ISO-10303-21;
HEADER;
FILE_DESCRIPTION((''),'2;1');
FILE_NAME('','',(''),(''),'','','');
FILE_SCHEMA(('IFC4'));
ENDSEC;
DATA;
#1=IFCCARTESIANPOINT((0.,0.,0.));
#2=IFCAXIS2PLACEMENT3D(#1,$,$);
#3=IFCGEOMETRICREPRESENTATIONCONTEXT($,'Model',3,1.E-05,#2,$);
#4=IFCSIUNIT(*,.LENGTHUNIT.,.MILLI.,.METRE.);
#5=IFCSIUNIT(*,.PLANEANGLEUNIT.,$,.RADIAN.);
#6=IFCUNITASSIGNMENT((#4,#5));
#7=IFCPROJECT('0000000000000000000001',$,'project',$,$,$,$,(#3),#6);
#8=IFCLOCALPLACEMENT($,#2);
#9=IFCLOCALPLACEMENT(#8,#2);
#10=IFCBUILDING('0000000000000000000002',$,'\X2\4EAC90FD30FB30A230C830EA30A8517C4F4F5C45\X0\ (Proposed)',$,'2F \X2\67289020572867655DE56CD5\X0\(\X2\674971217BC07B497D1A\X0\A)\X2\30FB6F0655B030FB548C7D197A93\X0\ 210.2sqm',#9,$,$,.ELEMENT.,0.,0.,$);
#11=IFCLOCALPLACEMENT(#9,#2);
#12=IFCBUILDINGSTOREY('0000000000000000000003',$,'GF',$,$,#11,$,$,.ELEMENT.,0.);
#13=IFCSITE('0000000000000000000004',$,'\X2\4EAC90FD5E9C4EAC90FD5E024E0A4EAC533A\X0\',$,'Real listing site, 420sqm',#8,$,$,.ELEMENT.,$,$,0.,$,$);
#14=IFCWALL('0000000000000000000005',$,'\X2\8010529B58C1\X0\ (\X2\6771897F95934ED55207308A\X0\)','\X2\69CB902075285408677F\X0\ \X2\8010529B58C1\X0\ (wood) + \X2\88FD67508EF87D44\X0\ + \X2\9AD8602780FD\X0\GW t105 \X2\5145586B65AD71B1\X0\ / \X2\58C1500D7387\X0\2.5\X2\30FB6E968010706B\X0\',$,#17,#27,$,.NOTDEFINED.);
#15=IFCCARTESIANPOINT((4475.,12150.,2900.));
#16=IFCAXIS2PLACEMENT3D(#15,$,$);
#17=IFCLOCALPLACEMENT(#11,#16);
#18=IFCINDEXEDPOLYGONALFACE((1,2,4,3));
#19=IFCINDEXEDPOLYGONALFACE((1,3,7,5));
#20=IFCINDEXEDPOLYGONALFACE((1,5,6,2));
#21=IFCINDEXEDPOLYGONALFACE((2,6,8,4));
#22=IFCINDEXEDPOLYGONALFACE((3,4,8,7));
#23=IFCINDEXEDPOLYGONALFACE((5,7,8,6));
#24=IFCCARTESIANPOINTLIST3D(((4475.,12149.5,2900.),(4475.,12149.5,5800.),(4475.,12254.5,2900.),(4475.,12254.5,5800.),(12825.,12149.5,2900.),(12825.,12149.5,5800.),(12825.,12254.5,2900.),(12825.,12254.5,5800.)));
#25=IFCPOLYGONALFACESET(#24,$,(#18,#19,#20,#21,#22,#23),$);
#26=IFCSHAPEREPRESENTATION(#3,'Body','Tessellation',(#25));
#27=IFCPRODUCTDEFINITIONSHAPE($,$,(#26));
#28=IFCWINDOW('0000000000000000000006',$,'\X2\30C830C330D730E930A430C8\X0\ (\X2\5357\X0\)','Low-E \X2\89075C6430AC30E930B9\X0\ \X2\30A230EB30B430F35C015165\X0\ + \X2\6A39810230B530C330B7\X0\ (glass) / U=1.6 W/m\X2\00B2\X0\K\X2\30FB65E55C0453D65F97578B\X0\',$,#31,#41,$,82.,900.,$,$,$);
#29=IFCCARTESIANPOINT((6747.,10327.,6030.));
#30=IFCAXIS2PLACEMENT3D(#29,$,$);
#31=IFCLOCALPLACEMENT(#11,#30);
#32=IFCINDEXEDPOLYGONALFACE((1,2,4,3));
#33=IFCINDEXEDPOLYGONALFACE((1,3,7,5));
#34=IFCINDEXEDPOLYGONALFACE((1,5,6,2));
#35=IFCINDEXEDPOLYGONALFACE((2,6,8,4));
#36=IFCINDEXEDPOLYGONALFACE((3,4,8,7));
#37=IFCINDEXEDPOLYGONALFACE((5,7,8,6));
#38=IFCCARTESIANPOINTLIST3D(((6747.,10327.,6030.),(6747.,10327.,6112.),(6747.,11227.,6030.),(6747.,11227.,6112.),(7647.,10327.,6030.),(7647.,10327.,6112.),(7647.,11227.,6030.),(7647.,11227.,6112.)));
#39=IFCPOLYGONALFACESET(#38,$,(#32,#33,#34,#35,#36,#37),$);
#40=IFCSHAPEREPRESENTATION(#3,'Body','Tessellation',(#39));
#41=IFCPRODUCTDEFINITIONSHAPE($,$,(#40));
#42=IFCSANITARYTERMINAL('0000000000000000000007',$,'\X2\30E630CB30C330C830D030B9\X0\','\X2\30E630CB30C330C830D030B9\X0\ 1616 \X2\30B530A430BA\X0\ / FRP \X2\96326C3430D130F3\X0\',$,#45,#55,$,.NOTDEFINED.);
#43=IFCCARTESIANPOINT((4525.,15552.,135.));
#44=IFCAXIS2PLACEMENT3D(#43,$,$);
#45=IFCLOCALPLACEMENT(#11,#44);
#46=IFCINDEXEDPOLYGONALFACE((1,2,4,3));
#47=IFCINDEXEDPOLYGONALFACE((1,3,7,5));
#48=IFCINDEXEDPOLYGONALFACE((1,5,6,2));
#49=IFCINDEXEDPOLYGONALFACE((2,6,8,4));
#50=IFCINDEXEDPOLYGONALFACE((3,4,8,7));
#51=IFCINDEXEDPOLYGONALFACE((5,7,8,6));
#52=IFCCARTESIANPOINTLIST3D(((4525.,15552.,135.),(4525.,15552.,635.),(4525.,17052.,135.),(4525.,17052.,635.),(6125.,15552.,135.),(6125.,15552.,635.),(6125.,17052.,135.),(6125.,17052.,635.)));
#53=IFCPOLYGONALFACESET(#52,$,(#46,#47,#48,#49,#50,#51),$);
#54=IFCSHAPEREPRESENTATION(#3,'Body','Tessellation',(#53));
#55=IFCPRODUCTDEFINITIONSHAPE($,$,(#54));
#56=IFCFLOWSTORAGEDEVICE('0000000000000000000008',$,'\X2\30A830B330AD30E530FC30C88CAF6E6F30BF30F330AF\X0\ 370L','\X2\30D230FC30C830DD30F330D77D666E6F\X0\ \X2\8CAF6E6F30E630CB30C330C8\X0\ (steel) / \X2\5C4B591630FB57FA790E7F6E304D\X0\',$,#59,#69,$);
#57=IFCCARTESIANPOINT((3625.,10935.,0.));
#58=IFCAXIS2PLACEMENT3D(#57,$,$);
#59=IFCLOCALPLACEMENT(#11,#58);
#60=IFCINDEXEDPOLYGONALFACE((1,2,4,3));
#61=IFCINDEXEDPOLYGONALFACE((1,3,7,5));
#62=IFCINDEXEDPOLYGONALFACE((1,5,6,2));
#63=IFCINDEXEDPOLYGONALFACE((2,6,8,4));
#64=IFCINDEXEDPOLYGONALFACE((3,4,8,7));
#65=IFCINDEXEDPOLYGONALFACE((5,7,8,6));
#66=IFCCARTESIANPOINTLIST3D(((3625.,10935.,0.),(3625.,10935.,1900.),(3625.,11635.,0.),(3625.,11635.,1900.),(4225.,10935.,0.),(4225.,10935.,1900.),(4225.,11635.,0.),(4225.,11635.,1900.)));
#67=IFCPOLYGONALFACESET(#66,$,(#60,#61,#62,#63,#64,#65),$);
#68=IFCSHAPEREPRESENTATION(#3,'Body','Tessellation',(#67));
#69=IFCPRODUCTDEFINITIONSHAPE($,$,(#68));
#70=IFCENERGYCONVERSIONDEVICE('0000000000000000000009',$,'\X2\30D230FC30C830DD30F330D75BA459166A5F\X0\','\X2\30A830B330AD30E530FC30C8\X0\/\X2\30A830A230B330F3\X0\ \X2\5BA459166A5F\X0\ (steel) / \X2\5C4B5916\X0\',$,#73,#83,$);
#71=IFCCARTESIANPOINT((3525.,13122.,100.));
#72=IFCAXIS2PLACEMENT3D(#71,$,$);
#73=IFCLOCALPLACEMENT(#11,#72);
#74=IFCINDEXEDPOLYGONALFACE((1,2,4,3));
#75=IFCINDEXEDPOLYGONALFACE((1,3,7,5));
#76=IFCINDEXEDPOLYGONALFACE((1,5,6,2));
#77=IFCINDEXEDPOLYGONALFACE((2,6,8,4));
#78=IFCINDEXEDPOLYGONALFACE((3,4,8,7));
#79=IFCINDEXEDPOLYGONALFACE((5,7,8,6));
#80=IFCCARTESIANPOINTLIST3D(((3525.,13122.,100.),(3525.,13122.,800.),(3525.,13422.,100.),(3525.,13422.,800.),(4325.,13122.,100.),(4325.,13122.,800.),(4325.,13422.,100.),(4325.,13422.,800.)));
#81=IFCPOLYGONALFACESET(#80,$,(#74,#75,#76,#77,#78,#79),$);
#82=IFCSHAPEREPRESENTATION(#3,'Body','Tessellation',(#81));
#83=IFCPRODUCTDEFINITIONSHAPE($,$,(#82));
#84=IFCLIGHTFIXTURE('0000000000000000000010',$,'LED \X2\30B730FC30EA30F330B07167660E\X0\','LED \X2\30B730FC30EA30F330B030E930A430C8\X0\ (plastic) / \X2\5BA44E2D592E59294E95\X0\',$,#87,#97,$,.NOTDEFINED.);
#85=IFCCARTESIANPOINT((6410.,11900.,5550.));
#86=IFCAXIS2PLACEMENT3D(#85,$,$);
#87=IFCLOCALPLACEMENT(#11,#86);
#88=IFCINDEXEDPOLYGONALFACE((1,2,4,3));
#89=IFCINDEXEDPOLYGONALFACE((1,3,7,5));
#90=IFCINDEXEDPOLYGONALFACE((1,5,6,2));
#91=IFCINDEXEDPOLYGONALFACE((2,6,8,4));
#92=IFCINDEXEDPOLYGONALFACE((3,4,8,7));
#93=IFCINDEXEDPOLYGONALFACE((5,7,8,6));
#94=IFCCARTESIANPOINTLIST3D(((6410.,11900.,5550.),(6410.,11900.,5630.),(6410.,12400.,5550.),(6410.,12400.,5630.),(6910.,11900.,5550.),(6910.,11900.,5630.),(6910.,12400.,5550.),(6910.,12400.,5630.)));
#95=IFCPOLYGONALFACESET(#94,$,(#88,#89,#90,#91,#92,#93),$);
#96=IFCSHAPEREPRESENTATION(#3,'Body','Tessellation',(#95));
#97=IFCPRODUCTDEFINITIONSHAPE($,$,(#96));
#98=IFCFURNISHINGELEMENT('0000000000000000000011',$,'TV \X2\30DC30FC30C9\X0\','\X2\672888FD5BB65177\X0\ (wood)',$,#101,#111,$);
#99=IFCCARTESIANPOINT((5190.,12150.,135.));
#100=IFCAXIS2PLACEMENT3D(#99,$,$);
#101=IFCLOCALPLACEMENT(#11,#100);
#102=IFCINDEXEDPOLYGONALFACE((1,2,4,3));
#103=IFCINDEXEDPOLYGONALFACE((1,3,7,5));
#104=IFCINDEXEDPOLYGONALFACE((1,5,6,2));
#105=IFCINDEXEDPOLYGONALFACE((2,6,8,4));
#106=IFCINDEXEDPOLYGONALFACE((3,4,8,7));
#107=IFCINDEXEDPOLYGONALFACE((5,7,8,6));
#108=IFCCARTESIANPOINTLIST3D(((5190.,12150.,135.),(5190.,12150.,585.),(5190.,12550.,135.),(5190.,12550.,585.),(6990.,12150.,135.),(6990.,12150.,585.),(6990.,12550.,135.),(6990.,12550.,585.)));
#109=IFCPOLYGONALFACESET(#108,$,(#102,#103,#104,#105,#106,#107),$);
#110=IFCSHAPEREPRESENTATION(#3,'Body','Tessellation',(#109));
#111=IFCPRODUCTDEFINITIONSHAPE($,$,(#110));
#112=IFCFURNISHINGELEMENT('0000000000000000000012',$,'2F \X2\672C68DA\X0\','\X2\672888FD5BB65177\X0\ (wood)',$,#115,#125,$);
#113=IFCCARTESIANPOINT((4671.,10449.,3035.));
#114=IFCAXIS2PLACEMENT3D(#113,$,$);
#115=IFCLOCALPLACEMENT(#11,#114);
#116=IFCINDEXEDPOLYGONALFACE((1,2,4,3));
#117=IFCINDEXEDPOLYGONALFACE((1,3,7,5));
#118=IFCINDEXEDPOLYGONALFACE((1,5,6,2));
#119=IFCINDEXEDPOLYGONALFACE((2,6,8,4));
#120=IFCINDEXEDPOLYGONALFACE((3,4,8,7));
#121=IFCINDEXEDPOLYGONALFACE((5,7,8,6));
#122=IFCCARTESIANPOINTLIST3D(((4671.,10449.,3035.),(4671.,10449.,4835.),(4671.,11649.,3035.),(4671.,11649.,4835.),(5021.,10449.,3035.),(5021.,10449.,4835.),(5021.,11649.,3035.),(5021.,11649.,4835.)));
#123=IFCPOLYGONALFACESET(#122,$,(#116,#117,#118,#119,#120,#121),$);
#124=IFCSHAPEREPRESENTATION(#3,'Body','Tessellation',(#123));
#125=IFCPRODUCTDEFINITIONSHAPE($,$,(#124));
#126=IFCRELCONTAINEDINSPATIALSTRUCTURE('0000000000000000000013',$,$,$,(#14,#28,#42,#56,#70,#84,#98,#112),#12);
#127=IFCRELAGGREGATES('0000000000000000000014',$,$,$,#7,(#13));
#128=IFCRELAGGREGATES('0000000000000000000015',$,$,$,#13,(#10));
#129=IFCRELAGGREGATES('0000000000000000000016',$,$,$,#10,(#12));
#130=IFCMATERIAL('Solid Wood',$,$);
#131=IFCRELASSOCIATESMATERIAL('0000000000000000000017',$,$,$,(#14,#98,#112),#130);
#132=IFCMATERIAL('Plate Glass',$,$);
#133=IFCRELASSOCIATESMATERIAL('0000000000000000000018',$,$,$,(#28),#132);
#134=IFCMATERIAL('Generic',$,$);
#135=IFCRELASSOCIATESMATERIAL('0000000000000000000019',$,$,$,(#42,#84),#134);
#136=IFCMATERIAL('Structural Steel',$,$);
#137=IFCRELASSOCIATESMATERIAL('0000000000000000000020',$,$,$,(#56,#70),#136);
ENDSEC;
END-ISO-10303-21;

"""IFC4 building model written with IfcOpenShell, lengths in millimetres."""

from ifc_helpers import new_model, si_unit, frame, frame_2d, origin, place, context, project, spatial, rectangle, extrude, material, element, save


model = new_model("IFC4")

# Units and contexts
model_context = context("Model", 3, precision=1e-05, world=origin())
ifc_project = project(units=[si_unit("LENGTHUNIT", "METRE", prefix="MILLI"), si_unit("PLANEANGLEUNIT", "RADIAN")], contexts=[model_context])

# Site, building, storey
site_placement = place(None, origin())
site = spatial("IfcSite", under=ifc_project, at=site_placement, Name="京都府京都市上京区", ObjectType="Real listing site, 420sqm", CompositionType="ELEMENT", RefElevation=0.0)
building_placement = place(site_placement, origin())
building = spatial("IfcBuilding", under=site, at=building_placement, Name="京都・アトリエ兼住居 (Proposed)", ObjectType="2F 木造在来工法(杉無節等級A)・漆喰・和紙窓 210.2sqm", CompositionType="ELEMENT", ElevationOfRefHeight=0.0, ElevationOfTerrain=0.0)
storey_placement = place(building_placement, origin())
storey = spatial("IfcBuildingStorey", under=building, at=storey_placement, Name="GF", CompositionType="ELEMENT", Elevation=0.0)

# Shared definitions
ifc_material_1 = material(Name="Solid Wood")

# Wall
wall_1_placement = place(storey_placement, frame((4475.0, 12150.0, 2900.0)))
element("IfcWall", 1, at=wall_1_placement, inside=storey, material=ifc_material_1, Name="耐力壁 (東西間仕切り)", Description="構造用合板 耐力壁 (wood) + 製材軸組 + 高性能GW t105 充填断熱 / 壁倍率2.5・準耐火", PredefinedType="NOTDEFINED", context=model_context, shape_type="SweptSolid", body=[
    extrude(rectangle(XDim=8350.0, YDim=105.0, at=frame_2d((4175.0, 52.0))), frame((4475.0, 12150.0, 2900.0)), (0.0, 0.0, 1.0), 2900.0),
])

# Window
ifc_material_2 = material(Name="Plate Glass")
window_placement = place(storey_placement, frame((6747.0, 10327.0, 6030.0)))
element("IfcWindow", 2, at=window_placement, inside=storey, material=ifc_material_2, Name="トップライト (南)", Description="Low-E 複層ガラス アルゴン封入 + 樹脂サッシ (glass) / U=1.6 W/m²K・日射取得型", OverallHeight=82.0, OverallWidth=900.0, context=model_context, shape_type="SweptSolid", body=[
    extrude(rectangle(XDim=900.0, YDim=900.0, at=frame_2d((450.0, 450.0))), frame((6747.0, 10327.0, 6030.0)), (0.0, 0.0, 1.0), 82.0),
])

# Sanitary terminal
ifc_material_3 = material(Name="Generic")
sanitary_terminal_placement = place(storey_placement, frame((4525.0, 15552.0, 135.0)))
element("IfcSanitaryTerminal", 3, at=sanitary_terminal_placement, inside=storey, material=ifc_material_3, Name="ユニットバス", Description="ユニットバス 1616 サイズ / FRP 防水パン", PredefinedType="NOTDEFINED", context=model_context, shape_type="SweptSolid", body=[
    extrude(rectangle(XDim=1600.0, YDim=1500.0, at=frame_2d((800.0, 750.0))), frame((4525.0, 15552.0, 135.0)), (0.0, 0.0, 1.0), 500.0),
])

# Flow storage device
ifc_material_4 = material(Name="Structural Steel")
flow_storage_device_placement = place(storey_placement, frame((3625.0, 10935.0, 0.0)))
element("IfcFlowStorageDevice", 4, at=flow_storage_device_placement, inside=storey, material=ifc_material_4, Name="エコキュート貯湯タンク 370L", Description="ヒートポンプ給湯 貯湯ユニット (steel) / 屋外・基礎置き", context=model_context, shape_type="SweptSolid", body=[
    extrude(rectangle(XDim=600.0, YDim=700.0, at=frame_2d((300.0, 350.0))), frame((3625.0, 10935.0, 0.0)), (0.0, 0.0, 1.0), 1900.0),
])

# Energy conversion device
energy_conversion_device_placement = place(storey_placement, frame((3525.0, 13122.0, 100.0)))
element("IfcEnergyConversionDevice", 5, at=energy_conversion_device_placement, inside=storey, material=ifc_material_4, Name="ヒートポンプ室外機", Description="エコキュート/エアコン 室外機 (steel) / 屋外", context=model_context, shape_type="SweptSolid", body=[
    extrude(rectangle(XDim=800.0, YDim=300.0, at=frame_2d((400.0, 150.0))), frame((3525.0, 13122.0, 100.0)), (0.0, 0.0, 1.0), 700.0),
])

# Light fixture
light_fixture_placement = place(storey_placement, frame((6410.0, 11900.0, 5550.0)))
element("IfcLightFixture", 6, at=light_fixture_placement, inside=storey, material=ifc_material_3, Name="LED シーリング照明", Description="LED シーリングライト (plastic) / 室中央天井", PredefinedType="NOTDEFINED", context=model_context, shape_type="SweptSolid", body=[
    extrude(rectangle(XDim=500.0, YDim=500.0, at=frame_2d((250.0, 250.0))), frame((6410.0, 11900.0, 5550.0)), (0.0, 0.0, 1.0), 80.0),
])

# Furnishing elements
furnishing_1_placement = place(storey_placement, frame((5190.0, 12150.0, 135.0)))
element("IfcFurnishingElement", 7, at=furnishing_1_placement, inside=storey, material=ifc_material_1, Name="TV ボード", Description="木製家具 (wood)", context=model_context, shape_type="SweptSolid", body=[
    extrude(rectangle(XDim=1800.0, YDim=400.0, at=frame_2d((900.0, 200.0))), frame((5190.0, 12150.0, 135.0)), (0.0, 0.0, 1.0), 450.0),
])
furnishing_2_placement = place(storey_placement, frame((4671.0, 10449.0, 3035.0)))
element("IfcFurnishingElement", 8, at=furnishing_2_placement, inside=storey, material=ifc_material_1, Name="2F 本棚", Description="木製家具 (wood)", context=model_context, shape_type="SweptSolid", body=[
    extrude(rectangle(XDim=350.0, YDim=1200.0, at=frame_2d((175.0, 600.0))), frame((4671.0, 10449.0, 3035.0)), (0.0, 0.0, 1.0), 1800.0),
])

save(model, "model.ifc")
